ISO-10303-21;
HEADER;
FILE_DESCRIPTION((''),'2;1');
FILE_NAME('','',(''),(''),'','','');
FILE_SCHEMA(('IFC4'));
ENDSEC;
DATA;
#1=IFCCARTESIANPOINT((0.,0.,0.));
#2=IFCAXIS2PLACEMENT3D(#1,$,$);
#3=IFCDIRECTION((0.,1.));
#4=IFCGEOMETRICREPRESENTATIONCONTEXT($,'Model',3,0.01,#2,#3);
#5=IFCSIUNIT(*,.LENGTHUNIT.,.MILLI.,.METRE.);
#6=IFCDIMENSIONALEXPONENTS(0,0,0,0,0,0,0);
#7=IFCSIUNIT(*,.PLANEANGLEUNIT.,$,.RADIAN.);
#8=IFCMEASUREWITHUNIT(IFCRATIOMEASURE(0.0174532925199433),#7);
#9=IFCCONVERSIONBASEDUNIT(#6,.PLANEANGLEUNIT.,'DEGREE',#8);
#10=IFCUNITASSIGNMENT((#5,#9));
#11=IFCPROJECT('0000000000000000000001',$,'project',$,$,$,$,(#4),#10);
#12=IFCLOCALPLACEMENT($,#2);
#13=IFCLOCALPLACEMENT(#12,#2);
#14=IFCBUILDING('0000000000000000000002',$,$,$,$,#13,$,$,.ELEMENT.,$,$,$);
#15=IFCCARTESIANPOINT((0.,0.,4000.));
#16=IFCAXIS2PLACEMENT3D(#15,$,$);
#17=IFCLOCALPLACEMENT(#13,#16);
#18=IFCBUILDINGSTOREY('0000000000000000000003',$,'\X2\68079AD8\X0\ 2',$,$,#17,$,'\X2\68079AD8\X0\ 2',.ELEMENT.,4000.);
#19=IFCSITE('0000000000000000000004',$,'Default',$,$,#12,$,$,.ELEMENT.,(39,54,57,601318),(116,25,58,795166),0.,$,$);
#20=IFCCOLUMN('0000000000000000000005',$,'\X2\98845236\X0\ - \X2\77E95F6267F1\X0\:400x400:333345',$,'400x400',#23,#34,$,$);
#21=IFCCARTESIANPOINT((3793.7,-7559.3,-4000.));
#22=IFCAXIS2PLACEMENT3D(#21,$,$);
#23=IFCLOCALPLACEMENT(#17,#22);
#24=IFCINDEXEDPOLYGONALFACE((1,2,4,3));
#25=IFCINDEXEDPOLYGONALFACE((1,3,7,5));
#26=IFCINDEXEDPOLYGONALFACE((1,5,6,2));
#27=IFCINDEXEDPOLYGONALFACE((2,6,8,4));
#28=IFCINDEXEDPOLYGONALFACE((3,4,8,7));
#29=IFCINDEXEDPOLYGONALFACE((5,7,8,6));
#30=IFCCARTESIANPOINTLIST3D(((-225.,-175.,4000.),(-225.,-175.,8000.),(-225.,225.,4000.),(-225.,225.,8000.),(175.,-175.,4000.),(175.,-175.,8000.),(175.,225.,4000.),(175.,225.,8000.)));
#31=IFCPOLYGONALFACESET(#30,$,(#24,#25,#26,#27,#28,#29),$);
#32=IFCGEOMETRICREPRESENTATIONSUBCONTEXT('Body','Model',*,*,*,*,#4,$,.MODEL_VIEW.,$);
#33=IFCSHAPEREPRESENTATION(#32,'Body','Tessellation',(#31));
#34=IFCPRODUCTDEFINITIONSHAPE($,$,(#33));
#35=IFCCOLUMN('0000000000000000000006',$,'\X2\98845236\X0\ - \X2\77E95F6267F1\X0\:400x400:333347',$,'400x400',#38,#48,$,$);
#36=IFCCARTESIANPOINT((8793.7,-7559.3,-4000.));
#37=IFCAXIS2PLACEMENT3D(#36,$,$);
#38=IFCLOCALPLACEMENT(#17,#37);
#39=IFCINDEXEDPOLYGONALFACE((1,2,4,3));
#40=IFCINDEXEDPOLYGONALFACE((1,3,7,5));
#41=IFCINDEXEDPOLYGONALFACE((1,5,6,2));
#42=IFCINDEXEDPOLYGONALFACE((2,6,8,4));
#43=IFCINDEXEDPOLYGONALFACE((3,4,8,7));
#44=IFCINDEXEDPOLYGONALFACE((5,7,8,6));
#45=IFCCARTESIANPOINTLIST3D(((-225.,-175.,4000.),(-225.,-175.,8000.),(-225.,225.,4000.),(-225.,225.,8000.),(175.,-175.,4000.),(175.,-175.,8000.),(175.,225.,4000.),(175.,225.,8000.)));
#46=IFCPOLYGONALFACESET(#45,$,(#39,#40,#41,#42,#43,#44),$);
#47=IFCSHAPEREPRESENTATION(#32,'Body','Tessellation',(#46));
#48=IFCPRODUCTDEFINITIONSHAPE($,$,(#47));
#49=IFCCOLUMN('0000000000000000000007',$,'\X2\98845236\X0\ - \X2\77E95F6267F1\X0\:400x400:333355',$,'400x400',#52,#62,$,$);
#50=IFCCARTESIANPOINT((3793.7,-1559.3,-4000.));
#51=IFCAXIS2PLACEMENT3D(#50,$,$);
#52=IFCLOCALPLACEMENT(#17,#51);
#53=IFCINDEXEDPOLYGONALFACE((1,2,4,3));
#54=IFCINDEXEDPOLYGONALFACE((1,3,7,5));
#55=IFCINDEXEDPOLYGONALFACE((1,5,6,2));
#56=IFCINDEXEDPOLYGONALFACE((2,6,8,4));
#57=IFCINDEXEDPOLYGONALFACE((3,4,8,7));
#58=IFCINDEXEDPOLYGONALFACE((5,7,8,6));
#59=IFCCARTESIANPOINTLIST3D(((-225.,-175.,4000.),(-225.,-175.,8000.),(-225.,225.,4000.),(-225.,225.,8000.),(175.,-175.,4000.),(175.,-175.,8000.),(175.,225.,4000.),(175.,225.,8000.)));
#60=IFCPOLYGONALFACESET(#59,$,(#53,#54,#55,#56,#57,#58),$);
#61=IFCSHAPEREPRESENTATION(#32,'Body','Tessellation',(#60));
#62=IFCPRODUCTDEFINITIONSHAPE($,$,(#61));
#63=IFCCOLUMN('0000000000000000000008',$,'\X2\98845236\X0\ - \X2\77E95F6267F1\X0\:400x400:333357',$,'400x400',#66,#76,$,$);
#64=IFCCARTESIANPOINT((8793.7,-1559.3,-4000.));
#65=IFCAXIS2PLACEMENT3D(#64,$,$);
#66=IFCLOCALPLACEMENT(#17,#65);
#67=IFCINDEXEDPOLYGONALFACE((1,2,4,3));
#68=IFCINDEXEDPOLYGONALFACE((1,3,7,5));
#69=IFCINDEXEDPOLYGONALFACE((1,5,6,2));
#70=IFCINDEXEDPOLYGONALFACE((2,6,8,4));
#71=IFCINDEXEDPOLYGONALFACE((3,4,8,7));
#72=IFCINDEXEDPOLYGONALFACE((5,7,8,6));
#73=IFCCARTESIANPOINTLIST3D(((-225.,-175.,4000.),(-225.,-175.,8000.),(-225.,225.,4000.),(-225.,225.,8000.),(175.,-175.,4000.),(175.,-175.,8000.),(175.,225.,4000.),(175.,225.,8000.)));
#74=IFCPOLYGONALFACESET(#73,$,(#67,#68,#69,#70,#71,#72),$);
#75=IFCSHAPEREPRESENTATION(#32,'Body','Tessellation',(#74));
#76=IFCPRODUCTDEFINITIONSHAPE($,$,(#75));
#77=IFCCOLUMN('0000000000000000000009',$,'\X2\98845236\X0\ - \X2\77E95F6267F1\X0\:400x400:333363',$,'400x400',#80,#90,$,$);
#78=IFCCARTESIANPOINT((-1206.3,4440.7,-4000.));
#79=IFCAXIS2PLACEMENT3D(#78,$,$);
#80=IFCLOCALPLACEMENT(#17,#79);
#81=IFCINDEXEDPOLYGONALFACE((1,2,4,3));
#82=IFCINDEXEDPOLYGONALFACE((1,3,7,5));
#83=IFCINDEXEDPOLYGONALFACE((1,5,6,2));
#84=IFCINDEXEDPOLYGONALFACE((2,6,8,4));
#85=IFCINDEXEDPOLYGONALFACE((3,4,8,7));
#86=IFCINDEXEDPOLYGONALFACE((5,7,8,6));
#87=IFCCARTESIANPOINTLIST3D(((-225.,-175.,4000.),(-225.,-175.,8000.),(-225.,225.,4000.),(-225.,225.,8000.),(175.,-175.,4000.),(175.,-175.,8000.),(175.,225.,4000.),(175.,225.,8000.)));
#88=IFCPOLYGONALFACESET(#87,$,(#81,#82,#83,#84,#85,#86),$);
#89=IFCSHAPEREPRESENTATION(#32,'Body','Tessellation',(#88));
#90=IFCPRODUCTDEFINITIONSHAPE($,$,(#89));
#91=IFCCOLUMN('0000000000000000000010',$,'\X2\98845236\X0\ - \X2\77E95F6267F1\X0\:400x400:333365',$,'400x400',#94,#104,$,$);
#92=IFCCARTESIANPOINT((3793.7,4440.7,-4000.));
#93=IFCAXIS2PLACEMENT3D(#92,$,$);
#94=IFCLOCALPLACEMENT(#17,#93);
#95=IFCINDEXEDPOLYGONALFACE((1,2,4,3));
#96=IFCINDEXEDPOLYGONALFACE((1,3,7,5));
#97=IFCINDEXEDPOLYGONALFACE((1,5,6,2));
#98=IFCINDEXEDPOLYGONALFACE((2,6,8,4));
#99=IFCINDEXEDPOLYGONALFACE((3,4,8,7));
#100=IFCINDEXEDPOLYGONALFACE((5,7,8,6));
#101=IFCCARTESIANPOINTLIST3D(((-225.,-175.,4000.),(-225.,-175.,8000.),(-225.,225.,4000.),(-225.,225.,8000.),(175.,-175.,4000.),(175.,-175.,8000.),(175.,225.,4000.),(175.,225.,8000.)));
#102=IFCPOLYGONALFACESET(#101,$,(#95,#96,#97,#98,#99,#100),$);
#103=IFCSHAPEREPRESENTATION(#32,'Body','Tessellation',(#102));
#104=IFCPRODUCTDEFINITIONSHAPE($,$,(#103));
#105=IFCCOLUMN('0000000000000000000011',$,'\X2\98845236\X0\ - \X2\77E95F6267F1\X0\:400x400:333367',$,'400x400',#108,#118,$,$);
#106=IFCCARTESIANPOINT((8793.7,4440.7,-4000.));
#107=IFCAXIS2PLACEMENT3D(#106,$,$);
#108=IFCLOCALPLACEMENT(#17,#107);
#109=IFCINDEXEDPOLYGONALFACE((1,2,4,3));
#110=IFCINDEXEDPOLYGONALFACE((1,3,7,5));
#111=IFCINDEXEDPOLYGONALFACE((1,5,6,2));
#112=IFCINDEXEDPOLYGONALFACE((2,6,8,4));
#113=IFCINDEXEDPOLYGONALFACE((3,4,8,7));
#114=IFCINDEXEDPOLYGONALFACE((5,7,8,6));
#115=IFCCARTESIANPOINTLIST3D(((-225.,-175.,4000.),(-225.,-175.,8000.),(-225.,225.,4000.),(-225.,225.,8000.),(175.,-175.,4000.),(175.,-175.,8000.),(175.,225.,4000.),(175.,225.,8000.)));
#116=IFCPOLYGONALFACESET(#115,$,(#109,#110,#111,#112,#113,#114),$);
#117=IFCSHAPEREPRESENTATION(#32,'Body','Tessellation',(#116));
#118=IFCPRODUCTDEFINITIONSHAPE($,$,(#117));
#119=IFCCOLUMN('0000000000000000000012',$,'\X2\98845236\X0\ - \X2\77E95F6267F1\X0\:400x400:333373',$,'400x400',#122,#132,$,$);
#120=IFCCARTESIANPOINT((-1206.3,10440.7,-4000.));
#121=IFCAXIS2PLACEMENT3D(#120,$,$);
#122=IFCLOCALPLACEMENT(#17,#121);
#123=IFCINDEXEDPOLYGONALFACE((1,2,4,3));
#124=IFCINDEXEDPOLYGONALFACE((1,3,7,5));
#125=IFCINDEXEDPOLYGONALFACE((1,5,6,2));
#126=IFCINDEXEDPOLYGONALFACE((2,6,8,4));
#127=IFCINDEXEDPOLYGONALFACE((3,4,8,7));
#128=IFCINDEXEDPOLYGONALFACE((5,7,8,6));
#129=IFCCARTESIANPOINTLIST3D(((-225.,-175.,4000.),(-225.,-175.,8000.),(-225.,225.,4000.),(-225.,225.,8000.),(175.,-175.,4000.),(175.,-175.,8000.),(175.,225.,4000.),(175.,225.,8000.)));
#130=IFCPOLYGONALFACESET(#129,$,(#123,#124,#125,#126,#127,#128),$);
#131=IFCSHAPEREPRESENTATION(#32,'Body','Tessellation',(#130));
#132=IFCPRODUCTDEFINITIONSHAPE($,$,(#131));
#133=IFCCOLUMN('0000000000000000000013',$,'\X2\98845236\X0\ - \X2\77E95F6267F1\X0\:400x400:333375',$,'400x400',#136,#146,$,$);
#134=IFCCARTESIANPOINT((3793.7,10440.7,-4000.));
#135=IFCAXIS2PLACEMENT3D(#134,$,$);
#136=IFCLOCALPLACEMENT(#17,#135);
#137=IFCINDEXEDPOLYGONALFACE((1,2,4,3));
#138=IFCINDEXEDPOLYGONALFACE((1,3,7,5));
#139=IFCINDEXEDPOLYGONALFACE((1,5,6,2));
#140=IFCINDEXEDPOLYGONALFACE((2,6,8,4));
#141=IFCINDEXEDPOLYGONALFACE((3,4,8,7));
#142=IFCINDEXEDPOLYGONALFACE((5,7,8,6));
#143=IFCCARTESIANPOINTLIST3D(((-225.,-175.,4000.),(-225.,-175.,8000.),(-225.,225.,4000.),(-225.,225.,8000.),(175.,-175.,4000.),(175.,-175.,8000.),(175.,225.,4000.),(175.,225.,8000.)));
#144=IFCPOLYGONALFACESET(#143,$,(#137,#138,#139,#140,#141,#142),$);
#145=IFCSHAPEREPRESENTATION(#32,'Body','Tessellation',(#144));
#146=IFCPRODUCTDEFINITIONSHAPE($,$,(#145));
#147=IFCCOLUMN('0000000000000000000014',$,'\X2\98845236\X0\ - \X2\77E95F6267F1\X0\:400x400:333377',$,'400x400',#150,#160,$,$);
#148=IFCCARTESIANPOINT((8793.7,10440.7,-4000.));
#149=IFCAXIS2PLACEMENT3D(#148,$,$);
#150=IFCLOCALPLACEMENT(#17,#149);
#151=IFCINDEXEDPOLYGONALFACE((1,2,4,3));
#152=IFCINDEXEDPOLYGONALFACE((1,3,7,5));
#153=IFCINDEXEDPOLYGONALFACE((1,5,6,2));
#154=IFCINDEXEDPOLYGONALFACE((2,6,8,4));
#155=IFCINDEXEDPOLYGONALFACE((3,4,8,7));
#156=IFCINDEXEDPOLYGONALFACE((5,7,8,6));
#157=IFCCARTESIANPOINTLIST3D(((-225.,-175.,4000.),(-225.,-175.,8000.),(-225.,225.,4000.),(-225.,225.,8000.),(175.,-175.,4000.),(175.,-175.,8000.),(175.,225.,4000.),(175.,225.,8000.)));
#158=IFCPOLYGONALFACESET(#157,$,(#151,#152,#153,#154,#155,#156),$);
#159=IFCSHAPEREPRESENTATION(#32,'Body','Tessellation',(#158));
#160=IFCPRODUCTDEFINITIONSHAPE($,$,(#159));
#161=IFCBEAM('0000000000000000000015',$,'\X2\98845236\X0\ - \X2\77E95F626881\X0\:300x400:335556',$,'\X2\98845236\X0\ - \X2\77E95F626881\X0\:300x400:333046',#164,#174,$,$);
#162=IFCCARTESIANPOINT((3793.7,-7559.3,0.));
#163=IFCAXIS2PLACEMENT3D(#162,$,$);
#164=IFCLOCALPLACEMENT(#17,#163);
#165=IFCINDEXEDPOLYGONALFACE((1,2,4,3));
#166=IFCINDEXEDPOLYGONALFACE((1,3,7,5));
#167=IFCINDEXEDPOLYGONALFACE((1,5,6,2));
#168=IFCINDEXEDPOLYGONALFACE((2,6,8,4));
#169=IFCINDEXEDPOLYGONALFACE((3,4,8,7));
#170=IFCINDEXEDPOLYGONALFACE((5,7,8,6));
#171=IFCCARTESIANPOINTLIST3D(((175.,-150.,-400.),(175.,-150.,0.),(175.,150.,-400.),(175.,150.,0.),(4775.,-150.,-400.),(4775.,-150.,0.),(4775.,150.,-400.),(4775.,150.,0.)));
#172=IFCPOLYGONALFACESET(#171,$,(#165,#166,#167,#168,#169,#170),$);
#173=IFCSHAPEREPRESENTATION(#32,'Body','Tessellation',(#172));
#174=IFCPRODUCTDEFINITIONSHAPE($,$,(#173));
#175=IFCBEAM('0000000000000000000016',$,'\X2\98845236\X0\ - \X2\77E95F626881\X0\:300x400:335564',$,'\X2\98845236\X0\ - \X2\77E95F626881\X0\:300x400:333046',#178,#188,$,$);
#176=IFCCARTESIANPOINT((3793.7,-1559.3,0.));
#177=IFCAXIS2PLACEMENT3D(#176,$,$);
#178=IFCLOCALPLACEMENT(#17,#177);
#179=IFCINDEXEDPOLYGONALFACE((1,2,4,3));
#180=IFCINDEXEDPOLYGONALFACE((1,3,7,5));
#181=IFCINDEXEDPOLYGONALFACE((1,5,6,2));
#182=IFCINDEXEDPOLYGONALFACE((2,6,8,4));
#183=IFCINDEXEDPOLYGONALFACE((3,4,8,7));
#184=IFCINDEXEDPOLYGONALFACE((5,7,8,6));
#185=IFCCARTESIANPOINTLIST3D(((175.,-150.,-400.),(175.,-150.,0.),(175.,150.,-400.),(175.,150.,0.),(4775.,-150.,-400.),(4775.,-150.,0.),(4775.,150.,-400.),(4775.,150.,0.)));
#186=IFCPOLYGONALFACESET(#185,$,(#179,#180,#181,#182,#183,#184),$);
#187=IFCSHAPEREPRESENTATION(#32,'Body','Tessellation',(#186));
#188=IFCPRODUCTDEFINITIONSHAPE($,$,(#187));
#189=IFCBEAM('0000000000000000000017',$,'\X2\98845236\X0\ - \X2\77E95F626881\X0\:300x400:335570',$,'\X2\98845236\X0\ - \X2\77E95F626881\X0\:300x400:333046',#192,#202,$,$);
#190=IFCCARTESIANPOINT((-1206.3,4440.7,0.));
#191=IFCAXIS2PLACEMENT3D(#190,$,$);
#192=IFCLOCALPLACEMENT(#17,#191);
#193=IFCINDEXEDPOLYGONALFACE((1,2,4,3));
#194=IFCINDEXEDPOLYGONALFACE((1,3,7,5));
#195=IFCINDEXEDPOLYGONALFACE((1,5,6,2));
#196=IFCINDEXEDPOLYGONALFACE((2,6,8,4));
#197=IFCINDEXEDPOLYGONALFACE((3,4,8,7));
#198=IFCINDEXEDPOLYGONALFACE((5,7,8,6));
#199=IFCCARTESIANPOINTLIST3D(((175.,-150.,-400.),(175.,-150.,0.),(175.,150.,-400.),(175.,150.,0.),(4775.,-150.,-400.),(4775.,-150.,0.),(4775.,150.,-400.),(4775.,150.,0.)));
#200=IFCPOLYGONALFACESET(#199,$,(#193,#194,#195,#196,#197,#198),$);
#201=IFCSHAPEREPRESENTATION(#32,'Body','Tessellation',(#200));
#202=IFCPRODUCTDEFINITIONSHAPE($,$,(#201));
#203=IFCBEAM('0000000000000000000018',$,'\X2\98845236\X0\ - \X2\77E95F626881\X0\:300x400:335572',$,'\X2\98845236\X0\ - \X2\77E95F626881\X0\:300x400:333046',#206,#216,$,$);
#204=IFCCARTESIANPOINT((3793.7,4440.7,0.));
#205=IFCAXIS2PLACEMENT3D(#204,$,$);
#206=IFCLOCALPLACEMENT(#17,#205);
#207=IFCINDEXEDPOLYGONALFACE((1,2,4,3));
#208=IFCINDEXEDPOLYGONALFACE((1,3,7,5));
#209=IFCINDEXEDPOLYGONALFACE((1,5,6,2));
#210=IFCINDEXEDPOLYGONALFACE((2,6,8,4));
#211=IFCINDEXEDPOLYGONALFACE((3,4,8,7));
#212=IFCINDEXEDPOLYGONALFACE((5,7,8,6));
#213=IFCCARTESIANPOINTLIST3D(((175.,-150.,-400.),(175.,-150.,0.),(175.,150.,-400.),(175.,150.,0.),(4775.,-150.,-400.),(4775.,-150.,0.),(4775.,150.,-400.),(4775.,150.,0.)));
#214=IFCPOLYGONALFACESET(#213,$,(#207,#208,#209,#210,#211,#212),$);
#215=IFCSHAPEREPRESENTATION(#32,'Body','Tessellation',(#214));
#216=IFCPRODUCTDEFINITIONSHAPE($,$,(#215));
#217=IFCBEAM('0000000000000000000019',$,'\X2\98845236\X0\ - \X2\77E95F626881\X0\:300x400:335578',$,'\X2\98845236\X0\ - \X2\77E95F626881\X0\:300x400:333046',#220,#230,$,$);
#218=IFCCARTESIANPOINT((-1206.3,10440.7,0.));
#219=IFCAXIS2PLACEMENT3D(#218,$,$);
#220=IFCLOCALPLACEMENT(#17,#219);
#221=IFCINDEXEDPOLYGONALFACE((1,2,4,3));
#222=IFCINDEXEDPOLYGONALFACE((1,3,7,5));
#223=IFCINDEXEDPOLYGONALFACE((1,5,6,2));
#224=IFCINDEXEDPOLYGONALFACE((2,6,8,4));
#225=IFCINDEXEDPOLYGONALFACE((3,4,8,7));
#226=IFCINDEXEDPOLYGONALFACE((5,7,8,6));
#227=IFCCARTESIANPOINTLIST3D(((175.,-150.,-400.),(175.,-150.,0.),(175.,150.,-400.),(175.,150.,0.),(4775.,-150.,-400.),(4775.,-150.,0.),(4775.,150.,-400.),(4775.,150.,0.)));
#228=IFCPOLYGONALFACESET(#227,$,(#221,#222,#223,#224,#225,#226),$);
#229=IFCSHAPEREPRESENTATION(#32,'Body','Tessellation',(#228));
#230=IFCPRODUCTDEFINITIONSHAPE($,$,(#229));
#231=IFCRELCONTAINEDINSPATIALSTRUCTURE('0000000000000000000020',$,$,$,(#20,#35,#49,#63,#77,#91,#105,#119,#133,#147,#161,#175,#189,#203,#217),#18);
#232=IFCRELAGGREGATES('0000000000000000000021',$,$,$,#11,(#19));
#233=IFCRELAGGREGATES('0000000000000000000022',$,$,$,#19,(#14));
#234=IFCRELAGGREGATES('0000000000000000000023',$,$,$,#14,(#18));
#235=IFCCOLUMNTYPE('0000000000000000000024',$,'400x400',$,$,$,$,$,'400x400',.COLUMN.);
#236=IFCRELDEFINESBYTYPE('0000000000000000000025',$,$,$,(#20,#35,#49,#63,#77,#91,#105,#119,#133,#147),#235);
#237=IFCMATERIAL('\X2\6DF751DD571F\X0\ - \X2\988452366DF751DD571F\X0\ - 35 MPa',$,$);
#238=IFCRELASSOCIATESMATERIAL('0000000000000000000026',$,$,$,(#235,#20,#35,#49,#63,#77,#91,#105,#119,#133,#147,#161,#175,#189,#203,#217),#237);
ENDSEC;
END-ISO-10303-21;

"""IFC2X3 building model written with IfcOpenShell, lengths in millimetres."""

from ifc_helpers import new_model, entity, si_unit, converted_unit, direction, frame, frame_2d, origin, place, context, subcontext, project, spatial, rectangle, extrude, source, transform, mapped, material, type_object, type_shapes, element, save


model = new_model("IFC2X3")

# Units and contexts
model_context = context("Model", 3, precision=0.01, world=origin(), true_north=direction((0.0, 1.0)))
body_context = subcontext(model_context, "Body", "Model", "MODEL_VIEW")
ifc_project = project(units=[si_unit("LENGTHUNIT", "METRE", prefix="MILLI"), converted_unit("PLANEANGLEUNIT", "DEGREE", entity("IfcRatioMeasure", 0.0174532925199433), si_unit("PLANEANGLEUNIT", "RADIAN"), dimensions=[0, 0, 0, 0, 0, 0, 0])], contexts=[model_context])

# Site, building, storey
site_placement = place(None, origin())
site = spatial("IfcSite", under=ifc_project, at=site_placement, Name="Default", CompositionType="ELEMENT", RefLatitude=(39, 54, 57, 601318), RefLongitude=(116, 25, 58, 795166), RefElevation=0.0)
building_placement = place(site_placement, origin())
building = spatial("IfcBuilding", under=site, at=building_placement, CompositionType="ELEMENT")
storey_placement = place(building_placement, frame((0.0, 0.0, 4000.0)))
storey = spatial("IfcBuildingStorey", under=building, at=storey_placement, Name="标高 2", LongName="标高 2", CompositionType="ELEMENT", Elevation=4000.0)

# Columns
ifc_material_1 = material(Name="混凝土 - 预制混凝土 - 35 MPa")
column_type = type_object("IfcColumnType", Name="400x400", ElementType="400x400", PredefinedType="COLUMN", material=ifc_material_1)
shared_shape = source(origin(), body_context, "Body", "SweptSolid", [
    extrude(rectangle(XDim=400.0, YDim=400.0, at=frame_2d((0.0, 0.0), x_axis=(1.0, 0.0))), frame((-25.0, 25.0, 4000.0)), (0.0, 0.0, 1.0), 4000.0),
])
type_shapes(column_type, [shared_shape])
for number, where, name in (
    (1, (3793.7, -7559.3, -4000.0), "预制 - 矩形柱:400x400:333345"),
    (2, (8793.7, -7559.3, -4000.0), "预制 - 矩形柱:400x400:333347"),
    (3, (3793.7, -1559.3, -4000.0), "预制 - 矩形柱:400x400:333355"),
    (4, (8793.7, -1559.3, -4000.0), "预制 - 矩形柱:400x400:333357"),
    (5, (-1206.3, 4440.7, -4000.0), "预制 - 矩形柱:400x400:333363"),
    (6, (3793.7, 4440.7, -4000.0), "预制 - 矩形柱:400x400:333365"),
    (7, (8793.7, 4440.7, -4000.0), "预制 - 矩形柱:400x400:333367"),
    (8, (-1206.3, 10440.7, -4000.0), "预制 - 矩形柱:400x400:333373"),
    (9, (3793.7, 10440.7, -4000.0), "预制 - 矩形柱:400x400:333375"),
    (10, (8793.7, 10440.7, -4000.0), "预制 - 矩形柱:400x400:333377"),
):
    element("IfcColumn", number, at=place(storey_placement, frame(where)), inside=storey, type_object=column_type, material=ifc_material_1, Name=name, ObjectType="400x400", context=body_context, shape_type="MappedRepresentation", body=[
        mapped(shared_shape, transform((0.0, 0.0, 0.0), scale=1.0)),
    ])

# Beams
beam_1_placement = place(storey_placement, frame((3793.7, -7559.3, 0.0)))
element("IfcBeam", 11, at=beam_1_placement, inside=storey, material=ifc_material_1, Name="预制 - 矩形梁:300x400:335556", ObjectType="预制 - 矩形梁:300x400:333046", context=body_context, shape_type="SweptSolid", body=[
    extrude(rectangle(XDim=400.0, YDim=300.0, at=frame_2d((0.0, 0.0), x_axis=(1.0, 0.0))), frame((175.0, 0.0, -200.0), z_axis=(1.0, 0.0, 0.0), x_axis=(0.0, 0.0, -1.0)), (0.0, 0.0, 1.0), 4600.0),
])
beam_2_placement = place(storey_placement, frame((3793.7, -1559.3, 0.0)))
element("IfcBeam", 12, at=beam_2_placement, inside=storey, material=ifc_material_1, Name="预制 - 矩形梁:300x400:335564", ObjectType="预制 - 矩形梁:300x400:333046", context=body_context, shape_type="SweptSolid", body=[
    extrude(rectangle(XDim=400.0, YDim=300.0, at=frame_2d((0.0, 0.0), x_axis=(1.0, 0.0))), frame((175.0, 0.0, -200.0), z_axis=(1.0, 0.0, 0.0), x_axis=(0.0, 0.0, -1.0)), (0.0, 0.0, 1.0), 4600.0),
])
beam_3_placement = place(storey_placement, frame((-1206.3, 4440.7, 0.0)))
element("IfcBeam", 13, at=beam_3_placement, inside=storey, material=ifc_material_1, Name="预制 - 矩形梁:300x400:335570", ObjectType="预制 - 矩形梁:300x400:333046", context=body_context, shape_type="SweptSolid", body=[
    extrude(rectangle(XDim=400.0, YDim=300.0, at=frame_2d((0.0, 0.0), x_axis=(1.0, 0.0))), frame((175.0, 0.0, -200.0), z_axis=(1.0, 0.0, 0.0), x_axis=(0.0, 0.0, -1.0)), (0.0, 0.0, 1.0), 4600.0),
])
beam_4_placement = place(storey_placement, frame((3793.7, 4440.7, 0.0)))
element("IfcBeam", 14, at=beam_4_placement, inside=storey, material=ifc_material_1, Name="预制 - 矩形梁:300x400:335572", ObjectType="预制 - 矩形梁:300x400:333046", context=body_context, shape_type="SweptSolid", body=[
    extrude(rectangle(XDim=400.0, YDim=300.0, at=frame_2d((0.0, 0.0), x_axis=(1.0, 0.0))), frame((175.0, 0.0, -200.0), z_axis=(1.0, 0.0, 0.0), x_axis=(0.0, 0.0, -1.0)), (0.0, 0.0, 1.0), 4600.0),
])
beam_5_placement = place(storey_placement, frame((-1206.3, 10440.7, 0.0)))
element("IfcBeam", 15, at=beam_5_placement, inside=storey, material=ifc_material_1, Name="预制 - 矩形梁:300x400:335578", ObjectType="预制 - 矩形梁:300x400:333046", context=body_context, shape_type="SweptSolid", body=[
    extrude(rectangle(XDim=400.0, YDim=300.0, at=frame_2d((0.0, 0.0), x_axis=(1.0, 0.0))), frame((175.0, 0.0, -200.0), z_axis=(1.0, 0.0, 0.0), x_axis=(0.0, 0.0, -1.0)), (0.0, 0.0, 1.0), 4600.0),
])

save(model, "model.ifc")
